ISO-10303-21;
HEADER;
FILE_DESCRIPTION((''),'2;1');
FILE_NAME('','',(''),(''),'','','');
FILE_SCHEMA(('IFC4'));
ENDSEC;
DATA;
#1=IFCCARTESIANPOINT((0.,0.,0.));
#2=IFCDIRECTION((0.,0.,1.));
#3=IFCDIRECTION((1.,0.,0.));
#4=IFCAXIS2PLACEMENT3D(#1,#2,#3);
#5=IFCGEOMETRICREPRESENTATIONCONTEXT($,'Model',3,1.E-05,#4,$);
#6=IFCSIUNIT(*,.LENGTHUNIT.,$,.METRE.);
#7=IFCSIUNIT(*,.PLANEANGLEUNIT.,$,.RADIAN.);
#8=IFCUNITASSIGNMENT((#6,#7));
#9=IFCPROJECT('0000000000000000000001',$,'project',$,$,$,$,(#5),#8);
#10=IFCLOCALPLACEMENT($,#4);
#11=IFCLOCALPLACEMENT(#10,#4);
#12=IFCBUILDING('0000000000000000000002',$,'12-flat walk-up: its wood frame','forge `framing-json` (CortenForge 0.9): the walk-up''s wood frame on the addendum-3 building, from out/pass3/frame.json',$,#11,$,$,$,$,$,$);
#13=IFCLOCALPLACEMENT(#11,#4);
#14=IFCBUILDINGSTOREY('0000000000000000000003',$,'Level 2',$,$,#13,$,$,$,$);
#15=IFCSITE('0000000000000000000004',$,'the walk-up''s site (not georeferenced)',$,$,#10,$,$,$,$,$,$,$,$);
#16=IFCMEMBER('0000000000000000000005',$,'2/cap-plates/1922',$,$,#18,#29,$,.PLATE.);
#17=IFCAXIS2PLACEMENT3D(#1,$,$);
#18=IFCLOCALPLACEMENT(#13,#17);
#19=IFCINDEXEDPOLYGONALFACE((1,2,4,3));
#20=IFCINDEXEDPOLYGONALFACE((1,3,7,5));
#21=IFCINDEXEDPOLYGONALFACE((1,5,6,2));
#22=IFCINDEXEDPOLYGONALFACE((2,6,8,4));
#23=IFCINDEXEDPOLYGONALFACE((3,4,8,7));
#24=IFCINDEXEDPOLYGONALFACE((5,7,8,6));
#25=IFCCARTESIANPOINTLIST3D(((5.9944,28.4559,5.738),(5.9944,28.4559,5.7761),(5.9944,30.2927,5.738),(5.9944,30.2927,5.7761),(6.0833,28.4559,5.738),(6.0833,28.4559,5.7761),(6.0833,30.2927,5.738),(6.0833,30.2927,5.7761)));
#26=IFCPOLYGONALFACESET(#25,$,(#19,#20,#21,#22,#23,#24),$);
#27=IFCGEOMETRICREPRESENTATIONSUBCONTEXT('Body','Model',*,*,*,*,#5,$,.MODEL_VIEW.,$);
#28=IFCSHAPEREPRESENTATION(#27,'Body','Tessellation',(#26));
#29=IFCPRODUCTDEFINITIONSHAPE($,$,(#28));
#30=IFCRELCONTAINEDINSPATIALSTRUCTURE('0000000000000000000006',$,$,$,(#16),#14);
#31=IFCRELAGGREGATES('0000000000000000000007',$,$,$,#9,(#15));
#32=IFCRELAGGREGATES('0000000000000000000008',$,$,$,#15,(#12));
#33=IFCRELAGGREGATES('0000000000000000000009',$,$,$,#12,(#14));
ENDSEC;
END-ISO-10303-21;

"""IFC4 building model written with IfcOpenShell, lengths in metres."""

from ifc_helpers import new_model, si_unit, frame, frame_2d, origin, origin_with_axes, place, context, subcontext, project, spatial, rectangle, extrude, element, save


model = new_model("IFC4")

# Units and contexts
model_context = context("Model", 3, precision=1e-05, world=origin_with_axes())
body_context = subcontext(model_context, "Body", "Model", "MODEL_VIEW")
ifc_project = project(units=[si_unit("LENGTHUNIT", "METRE"), si_unit("PLANEANGLEUNIT", "RADIAN")], contexts=[model_context])

# Site, building, storey
site_placement = place(None, origin_with_axes())
site = spatial("IfcSite", under=ifc_project, at=site_placement, Name="the walk-up's site (not georeferenced)")
building_placement = place(site_placement, origin_with_axes())
building = spatial("IfcBuilding", under=site, at=building_placement, Name="12-flat walk-up: its wood frame", Description="forge `framing-json` (CortenForge 0.9): the walk-up's wood frame on the addendum-3 building, from out/pass3/frame.json")
storey_placement = place(building_placement, origin_with_axes())
storey = spatial("IfcBuildingStorey", under=building, at=storey_placement, Name="Level 2")

# Member
member_1_placement = place(storey_placement, frame((5.9944, 28.4559, 5.738), z_axis=(0.0, 0.0, 1.0), x_axis=(1.0, 0.0, 0.0)))
element("IfcMember", 1, at=member_1_placement, inside=storey, Name="2/cap-plates/1922", PredefinedType="PLATE", context=body_context, shape_type="SweptSolid", body=[
    extrude(rectangle(XDim=0.0889, YDim=1.8367, at=frame_2d((0.0445, 0.9184))), origin(), (0.0, 0.0, 1.0), 0.0381),
])

save(model, "model.ifc")
